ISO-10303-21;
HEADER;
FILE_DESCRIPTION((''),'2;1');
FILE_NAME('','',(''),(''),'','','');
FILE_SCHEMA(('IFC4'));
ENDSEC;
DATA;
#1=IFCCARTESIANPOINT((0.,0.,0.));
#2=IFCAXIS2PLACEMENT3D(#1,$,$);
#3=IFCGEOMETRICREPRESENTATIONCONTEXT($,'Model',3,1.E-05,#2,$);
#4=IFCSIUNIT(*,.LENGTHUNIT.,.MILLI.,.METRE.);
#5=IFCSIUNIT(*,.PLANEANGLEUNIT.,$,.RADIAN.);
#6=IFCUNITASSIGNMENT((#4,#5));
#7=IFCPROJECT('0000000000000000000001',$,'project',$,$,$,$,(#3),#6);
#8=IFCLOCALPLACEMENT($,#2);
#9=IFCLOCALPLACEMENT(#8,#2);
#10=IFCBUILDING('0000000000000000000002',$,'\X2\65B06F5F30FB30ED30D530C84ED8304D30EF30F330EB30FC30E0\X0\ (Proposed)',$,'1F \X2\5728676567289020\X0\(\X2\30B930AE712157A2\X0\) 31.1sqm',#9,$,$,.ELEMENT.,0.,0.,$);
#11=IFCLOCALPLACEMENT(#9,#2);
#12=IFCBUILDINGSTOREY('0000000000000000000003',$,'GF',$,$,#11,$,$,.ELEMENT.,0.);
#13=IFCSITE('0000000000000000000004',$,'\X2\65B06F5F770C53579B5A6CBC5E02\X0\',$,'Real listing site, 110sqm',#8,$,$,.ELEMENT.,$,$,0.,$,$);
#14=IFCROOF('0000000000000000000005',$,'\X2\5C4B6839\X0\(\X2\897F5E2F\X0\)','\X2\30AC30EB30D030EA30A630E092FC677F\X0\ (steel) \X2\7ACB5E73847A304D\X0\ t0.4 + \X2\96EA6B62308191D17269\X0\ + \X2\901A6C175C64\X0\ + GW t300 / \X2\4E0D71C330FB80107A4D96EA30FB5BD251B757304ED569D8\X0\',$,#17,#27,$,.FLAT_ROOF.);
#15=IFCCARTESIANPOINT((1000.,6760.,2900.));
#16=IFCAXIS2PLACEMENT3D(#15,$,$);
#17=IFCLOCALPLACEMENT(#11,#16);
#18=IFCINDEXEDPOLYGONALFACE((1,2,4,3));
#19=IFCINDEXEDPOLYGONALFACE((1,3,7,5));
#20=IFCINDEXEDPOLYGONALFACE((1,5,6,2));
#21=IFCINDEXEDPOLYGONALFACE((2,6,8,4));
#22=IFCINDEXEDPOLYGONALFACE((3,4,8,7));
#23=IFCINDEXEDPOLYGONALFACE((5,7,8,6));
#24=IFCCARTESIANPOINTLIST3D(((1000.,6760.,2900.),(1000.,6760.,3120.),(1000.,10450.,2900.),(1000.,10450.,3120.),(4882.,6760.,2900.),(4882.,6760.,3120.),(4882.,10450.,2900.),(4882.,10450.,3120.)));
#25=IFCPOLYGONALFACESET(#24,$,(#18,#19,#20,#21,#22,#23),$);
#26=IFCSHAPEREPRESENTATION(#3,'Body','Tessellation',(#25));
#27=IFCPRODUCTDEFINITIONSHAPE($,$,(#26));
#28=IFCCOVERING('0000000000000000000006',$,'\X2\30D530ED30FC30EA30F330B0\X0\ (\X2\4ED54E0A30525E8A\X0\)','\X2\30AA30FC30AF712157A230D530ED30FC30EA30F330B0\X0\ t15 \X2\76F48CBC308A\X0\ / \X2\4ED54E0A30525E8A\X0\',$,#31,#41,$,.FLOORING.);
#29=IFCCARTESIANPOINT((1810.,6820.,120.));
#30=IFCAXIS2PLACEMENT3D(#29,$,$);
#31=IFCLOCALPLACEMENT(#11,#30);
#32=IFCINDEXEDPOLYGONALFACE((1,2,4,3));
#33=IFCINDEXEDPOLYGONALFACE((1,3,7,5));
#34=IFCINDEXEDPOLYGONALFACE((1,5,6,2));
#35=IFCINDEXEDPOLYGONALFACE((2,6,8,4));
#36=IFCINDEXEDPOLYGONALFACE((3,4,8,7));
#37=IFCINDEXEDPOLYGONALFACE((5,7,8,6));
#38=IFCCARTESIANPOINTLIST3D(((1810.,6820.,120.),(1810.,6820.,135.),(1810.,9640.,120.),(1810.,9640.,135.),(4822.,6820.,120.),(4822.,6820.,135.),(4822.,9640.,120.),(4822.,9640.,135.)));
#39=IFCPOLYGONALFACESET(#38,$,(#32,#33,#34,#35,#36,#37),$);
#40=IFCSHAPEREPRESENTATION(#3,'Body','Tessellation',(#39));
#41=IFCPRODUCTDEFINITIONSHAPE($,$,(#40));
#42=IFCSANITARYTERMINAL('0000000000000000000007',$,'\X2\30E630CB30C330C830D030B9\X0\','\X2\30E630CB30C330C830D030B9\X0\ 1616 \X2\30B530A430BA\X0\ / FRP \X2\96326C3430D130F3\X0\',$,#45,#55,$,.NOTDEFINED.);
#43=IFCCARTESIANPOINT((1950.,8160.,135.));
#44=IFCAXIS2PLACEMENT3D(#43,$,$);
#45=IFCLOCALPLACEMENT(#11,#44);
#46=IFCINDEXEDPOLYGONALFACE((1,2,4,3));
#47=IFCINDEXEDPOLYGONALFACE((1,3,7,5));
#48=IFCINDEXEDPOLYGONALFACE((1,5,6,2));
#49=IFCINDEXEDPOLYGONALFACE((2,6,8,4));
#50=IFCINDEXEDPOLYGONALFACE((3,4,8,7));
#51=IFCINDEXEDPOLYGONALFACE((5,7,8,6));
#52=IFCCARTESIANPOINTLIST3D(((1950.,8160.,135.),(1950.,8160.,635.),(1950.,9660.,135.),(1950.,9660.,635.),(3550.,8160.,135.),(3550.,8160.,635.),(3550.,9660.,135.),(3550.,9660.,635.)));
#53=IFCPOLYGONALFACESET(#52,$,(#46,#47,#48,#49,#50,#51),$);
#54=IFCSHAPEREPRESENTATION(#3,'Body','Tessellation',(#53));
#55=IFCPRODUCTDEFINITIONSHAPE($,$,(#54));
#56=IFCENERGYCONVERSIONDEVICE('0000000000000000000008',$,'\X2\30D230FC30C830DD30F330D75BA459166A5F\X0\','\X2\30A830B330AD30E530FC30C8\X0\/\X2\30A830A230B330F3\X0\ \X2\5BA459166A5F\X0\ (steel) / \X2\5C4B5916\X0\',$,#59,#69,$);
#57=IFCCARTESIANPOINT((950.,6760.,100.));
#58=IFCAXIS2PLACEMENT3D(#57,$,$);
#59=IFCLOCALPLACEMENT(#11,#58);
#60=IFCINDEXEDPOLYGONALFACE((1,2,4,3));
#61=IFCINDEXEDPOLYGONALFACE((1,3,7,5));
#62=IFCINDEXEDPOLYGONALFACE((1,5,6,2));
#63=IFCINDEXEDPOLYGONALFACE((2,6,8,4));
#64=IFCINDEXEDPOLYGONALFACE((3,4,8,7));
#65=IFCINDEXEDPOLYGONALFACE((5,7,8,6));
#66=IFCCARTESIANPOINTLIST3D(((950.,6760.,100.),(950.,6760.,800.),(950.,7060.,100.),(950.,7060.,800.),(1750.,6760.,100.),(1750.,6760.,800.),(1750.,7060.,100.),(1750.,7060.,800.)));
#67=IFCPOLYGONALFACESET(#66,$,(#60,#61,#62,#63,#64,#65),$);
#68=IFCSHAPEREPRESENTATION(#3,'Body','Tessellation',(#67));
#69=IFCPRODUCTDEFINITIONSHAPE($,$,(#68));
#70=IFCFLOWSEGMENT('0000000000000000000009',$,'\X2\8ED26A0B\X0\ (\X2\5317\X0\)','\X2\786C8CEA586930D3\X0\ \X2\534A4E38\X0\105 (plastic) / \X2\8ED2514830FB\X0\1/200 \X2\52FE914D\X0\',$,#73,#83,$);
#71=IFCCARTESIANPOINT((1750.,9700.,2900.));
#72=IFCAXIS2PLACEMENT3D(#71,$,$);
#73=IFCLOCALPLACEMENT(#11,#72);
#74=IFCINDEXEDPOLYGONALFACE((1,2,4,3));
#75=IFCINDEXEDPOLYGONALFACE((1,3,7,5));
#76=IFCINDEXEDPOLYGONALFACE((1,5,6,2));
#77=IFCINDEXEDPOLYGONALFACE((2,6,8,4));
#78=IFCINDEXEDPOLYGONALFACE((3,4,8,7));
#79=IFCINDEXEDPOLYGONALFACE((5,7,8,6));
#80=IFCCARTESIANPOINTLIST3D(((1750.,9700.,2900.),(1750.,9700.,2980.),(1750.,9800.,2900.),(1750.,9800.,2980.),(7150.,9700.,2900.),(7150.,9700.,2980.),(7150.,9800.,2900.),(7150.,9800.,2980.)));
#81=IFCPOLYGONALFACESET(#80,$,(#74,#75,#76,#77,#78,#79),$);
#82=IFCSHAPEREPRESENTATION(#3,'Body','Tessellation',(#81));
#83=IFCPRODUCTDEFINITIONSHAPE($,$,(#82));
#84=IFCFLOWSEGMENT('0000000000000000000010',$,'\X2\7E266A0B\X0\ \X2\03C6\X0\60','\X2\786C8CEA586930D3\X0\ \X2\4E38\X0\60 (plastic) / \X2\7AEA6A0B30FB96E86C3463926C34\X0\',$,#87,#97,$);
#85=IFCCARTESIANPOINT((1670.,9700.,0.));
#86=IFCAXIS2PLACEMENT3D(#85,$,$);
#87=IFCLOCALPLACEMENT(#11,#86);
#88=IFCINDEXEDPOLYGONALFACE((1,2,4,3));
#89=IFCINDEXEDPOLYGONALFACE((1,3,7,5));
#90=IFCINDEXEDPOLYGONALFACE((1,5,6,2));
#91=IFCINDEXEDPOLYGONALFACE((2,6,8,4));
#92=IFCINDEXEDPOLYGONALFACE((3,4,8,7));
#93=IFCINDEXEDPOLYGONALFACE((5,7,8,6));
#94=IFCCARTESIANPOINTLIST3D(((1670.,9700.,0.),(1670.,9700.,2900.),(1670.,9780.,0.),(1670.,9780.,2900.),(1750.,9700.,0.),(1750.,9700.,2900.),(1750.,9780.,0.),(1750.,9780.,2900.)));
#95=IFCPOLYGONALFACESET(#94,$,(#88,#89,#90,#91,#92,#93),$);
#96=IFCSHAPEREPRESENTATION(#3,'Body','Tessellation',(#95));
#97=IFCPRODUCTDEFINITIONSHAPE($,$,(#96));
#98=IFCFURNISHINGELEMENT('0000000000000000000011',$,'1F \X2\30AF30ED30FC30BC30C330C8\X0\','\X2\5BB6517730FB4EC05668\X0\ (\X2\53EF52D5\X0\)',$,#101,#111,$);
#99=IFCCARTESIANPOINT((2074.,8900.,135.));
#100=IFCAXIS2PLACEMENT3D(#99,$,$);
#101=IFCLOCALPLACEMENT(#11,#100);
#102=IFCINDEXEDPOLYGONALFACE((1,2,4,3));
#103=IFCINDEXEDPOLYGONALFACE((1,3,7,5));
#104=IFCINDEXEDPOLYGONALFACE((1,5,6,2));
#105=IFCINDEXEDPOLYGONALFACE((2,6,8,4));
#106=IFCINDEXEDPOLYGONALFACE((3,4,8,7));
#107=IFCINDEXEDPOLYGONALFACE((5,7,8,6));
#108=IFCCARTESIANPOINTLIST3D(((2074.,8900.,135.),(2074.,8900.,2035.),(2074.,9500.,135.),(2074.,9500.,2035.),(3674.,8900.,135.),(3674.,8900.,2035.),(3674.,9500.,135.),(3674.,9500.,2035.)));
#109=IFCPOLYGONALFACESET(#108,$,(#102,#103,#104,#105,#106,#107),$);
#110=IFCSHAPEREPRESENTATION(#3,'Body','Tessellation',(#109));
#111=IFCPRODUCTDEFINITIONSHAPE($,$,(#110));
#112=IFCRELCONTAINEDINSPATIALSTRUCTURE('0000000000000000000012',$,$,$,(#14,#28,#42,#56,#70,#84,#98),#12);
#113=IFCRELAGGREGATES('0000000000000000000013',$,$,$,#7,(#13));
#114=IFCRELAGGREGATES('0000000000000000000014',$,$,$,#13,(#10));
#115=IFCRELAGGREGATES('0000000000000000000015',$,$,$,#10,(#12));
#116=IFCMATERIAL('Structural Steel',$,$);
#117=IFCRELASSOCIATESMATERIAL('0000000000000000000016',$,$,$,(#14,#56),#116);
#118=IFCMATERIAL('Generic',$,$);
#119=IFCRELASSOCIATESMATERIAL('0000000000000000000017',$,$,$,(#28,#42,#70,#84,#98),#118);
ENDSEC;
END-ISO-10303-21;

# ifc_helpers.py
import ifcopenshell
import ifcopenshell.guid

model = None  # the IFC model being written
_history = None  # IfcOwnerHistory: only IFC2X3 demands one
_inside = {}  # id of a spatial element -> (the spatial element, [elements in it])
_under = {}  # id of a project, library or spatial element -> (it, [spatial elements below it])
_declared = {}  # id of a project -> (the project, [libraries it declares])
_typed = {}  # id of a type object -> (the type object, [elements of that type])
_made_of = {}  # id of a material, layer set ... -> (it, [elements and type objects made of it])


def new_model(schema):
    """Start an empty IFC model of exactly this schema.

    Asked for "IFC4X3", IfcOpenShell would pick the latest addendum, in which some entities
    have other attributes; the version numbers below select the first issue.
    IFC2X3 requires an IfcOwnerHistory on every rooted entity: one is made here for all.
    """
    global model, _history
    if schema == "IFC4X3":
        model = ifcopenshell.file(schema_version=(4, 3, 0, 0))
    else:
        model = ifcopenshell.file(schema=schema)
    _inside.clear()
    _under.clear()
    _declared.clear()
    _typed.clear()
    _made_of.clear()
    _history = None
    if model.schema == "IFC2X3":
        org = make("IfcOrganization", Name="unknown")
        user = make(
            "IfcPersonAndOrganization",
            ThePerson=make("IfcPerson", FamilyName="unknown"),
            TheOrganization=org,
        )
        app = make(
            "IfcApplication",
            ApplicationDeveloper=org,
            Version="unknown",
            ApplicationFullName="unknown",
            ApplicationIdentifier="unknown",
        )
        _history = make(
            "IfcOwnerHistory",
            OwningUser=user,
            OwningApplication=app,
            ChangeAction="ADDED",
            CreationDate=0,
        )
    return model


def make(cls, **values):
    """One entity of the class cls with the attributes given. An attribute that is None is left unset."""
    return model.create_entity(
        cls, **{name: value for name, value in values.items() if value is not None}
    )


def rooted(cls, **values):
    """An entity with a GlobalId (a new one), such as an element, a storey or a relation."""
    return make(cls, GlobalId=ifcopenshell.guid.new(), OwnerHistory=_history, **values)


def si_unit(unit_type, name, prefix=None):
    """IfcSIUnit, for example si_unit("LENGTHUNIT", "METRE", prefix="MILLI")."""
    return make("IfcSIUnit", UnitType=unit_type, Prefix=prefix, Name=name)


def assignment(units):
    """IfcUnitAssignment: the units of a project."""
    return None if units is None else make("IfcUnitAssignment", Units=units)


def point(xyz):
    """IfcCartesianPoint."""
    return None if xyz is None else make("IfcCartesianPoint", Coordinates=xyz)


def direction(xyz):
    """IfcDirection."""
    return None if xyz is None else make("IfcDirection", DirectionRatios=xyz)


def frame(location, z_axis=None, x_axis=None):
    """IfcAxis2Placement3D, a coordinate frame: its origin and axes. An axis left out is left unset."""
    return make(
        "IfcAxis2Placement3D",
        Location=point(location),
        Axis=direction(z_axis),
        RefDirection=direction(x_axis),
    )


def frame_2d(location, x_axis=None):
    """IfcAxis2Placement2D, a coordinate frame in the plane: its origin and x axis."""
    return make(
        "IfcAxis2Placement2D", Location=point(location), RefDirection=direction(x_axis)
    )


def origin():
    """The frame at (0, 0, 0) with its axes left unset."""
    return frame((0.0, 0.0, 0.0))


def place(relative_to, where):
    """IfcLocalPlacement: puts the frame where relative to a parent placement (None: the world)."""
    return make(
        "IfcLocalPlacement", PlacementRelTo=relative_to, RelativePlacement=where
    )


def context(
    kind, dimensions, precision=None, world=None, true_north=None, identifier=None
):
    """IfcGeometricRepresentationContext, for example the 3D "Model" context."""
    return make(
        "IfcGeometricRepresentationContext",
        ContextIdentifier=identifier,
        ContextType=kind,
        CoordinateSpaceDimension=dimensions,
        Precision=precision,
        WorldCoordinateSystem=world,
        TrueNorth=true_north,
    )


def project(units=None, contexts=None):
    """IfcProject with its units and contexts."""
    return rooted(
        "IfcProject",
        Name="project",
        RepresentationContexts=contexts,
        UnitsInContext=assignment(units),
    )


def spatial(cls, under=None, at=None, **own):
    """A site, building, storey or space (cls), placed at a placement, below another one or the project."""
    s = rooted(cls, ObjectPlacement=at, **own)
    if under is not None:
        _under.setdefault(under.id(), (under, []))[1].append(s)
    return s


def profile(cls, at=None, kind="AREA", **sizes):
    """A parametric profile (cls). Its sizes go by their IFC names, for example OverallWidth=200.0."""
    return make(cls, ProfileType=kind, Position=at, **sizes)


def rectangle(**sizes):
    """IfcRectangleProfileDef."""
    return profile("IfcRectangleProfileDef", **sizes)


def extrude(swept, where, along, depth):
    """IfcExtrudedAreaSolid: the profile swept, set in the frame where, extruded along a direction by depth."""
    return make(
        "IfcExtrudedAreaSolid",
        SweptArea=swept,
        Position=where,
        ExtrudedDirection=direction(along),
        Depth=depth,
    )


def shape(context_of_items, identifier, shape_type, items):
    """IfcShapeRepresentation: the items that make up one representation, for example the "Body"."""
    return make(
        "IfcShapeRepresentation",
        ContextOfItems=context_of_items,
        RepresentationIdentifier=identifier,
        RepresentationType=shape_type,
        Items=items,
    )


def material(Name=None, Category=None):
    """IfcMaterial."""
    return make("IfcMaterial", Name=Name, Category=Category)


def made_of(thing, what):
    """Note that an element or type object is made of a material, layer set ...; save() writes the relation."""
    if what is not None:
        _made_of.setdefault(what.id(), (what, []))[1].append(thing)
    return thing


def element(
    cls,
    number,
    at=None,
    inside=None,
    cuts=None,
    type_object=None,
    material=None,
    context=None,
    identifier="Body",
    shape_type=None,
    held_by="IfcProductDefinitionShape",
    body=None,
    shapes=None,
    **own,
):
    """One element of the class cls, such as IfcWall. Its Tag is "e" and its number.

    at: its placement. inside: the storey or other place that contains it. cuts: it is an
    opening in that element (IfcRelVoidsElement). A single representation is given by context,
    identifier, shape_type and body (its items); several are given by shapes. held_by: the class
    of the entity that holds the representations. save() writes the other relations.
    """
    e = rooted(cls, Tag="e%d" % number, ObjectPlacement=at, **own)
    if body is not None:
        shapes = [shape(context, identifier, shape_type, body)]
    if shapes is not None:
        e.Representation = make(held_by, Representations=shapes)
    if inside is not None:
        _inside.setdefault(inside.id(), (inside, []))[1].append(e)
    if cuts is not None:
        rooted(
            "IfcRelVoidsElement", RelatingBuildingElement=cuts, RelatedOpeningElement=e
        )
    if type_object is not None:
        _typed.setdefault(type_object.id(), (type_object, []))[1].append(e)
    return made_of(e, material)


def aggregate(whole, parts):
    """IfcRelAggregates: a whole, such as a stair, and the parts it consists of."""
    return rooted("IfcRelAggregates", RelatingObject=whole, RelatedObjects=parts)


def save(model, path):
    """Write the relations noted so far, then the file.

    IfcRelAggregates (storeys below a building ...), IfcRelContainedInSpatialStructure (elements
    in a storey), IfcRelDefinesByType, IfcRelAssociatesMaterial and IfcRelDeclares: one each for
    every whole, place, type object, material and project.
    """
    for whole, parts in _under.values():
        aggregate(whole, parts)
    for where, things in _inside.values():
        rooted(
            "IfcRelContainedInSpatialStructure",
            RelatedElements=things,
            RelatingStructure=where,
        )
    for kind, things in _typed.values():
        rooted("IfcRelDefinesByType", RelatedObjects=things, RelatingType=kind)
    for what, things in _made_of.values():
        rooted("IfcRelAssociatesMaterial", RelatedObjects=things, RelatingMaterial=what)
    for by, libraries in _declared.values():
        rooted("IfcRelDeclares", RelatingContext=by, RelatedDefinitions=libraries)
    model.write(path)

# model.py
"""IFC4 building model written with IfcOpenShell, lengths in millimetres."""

from ifc_helpers import new_model, si_unit, frame, frame_2d, origin, place, context, project, spatial, rectangle, extrude, material, element, save


model = new_model("IFC4")

# Units and contexts
model_context = context("Model", 3, precision=1e-05, world=origin())
ifc_project = project(units=[si_unit("LENGTHUNIT", "METRE", prefix="MILLI"), si_unit("PLANEANGLEUNIT", "RADIAN")], contexts=[model_context])

# Site, building, storey
site_placement = place(None, origin())
site = spatial("IfcSite", under=ifc_project, at=site_placement, Name="新潟県南魚沼市", ObjectType="Real listing site, 110sqm", CompositionType="ELEMENT", RefElevation=0.0)
building_placement = place(site_placement, origin())
building = spatial("IfcBuilding", under=site, at=building_placement, Name="新潟・ロフト付きワンルーム (Proposed)", ObjectType="1F 在来木造(スギ無垢) 31.1sqm", CompositionType="ELEMENT", ElevationOfRefHeight=0.0, ElevationOfTerrain=0.0)
storey_placement = place(building_placement, origin())
storey = spatial("IfcBuildingStorey", under=building, at=storey_placement, Name="GF", CompositionType="ELEMENT", Elevation=0.0)

# Roof
ifc_material_1 = material(Name="Structural Steel")
roof_placement = place(storey_placement, frame((1000.0, 6760.0, 2900.0)))
element("IfcRoof", 1, at=roof_placement, inside=storey, material=ifc_material_1, Name="屋根(西帯)", Description="ガルバリウム鋼板 (steel) 立平葺き t0.4 + 雪止め金物 + 通気層 + GW t300 / 不燃・耐積雪・寒冷地仕様", PredefinedType="FLAT_ROOF", context=model_context, shape_type="SweptSolid", body=[
    extrude(rectangle(XDim=3882.0, YDim=3690.0, at=frame_2d((1941.0, 1845.0))), frame((1000.0, 6760.0, 2900.0)), (0.0, 0.0, 1.0), 220.0),
])

# Covering
ifc_material_2 = material(Name="Generic")
covering_placement = place(storey_placement, frame((1810.0, 6820.0, 120.0)))
element("IfcCovering", 2, at=covering_placement, inside=storey, material=ifc_material_2, Name="フローリング (仕上げ床)", Description="オーク無垢フローリング t15 直貼り / 仕上げ床", PredefinedType="FLOORING", context=model_context, shape_type="SweptSolid", body=[
    extrude(rectangle(XDim=3012.0, YDim=2820.0, at=frame_2d((1506.0, 1410.0))), frame((1810.0, 6820.0, 120.0)), (0.0, 0.0, 1.0), 15.0),
])

# Sanitary terminal
sanitary_terminal_placement = place(storey_placement, frame((1950.0, 8160.0, 135.0)))
element("IfcSanitaryTerminal", 3, at=sanitary_terminal_placement, inside=storey, material=ifc_material_2, Name="ユニットバス", Description="ユニットバス 1616 サイズ / FRP 防水パン", PredefinedType="NOTDEFINED", context=model_context, shape_type="SweptSolid", body=[
    extrude(rectangle(XDim=1600.0, YDim=1500.0, at=frame_2d((800.0, 750.0))), frame((1950.0, 8160.0, 135.0)), (0.0, 0.0, 1.0), 500.0),
])

# Energy conversion device
energy_conversion_device_placement = place(storey_placement, frame((950.0, 6760.0, 100.0)))
element("IfcEnergyConversionDevice", 4, at=energy_conversion_device_placement, inside=storey, material=ifc_material_1, Name="ヒートポンプ室外機", Description="エコキュート/エアコン 室外機 (steel) / 屋外", context=model_context, shape_type="SweptSolid", body=[
    extrude(rectangle(XDim=800.0, YDim=300.0, at=frame_2d((400.0, 150.0))), frame((950.0, 6760.0, 100.0)), (0.0, 0.0, 1.0), 700.0),
])

# Flow segments
flow_segment_1_placement = place(storey_placement, frame((1750.0, 9700.0, 2900.0)))
element("IfcFlowSegment", 5, at=flow_segment_1_placement, inside=storey, material=ifc_material_2, Name="軒樋 (北)", Description="硬質塩ビ 半丸105 (plastic) / 軒先・1/200 勾配", context=model_context, shape_type="SweptSolid", body=[
    extrude(rectangle(XDim=5400.0, YDim=100.0, at=frame_2d((2700.0, 50.0))), frame((1750.0, 9700.0, 2900.0)), (0.0, 0.0, 1.0), 80.0),
])
flow_segment_2_placement = place(storey_placement, frame((1670.0, 9700.0, 0.0)))
element("IfcFlowSegment", 6, at=flow_segment_2_placement, inside=storey, material=ifc_material_2, Name="縦樋 φ60", Description="硬質塩ビ 丸60 (plastic) / 竪樋・雨水排水", context=model_context, shape_type="SweptSolid", body=[
    extrude(rectangle(XDim=80.0, YDim=80.0, at=frame_2d((40.0, 40.0))), frame((1670.0, 9700.0, 0.0)), (0.0, 0.0, 1.0), 2900.0),
])

# Furnishing element
furnishing_placement = place(storey_placement, frame((2074.0, 8900.0, 135.0)))
element("IfcFurnishingElement", 7, at=furnishing_placement, inside=storey, material=ifc_material_2, Name="1F クローゼット", Description="家具・什器 (可動)", context=model_context, shape_type="SweptSolid", body=[
    extrude(rectangle(XDim=1600.0, YDim=600.0, at=frame_2d((800.0, 300.0))), frame((2074.0, 8900.0, 135.0)), (0.0, 0.0, 1.0), 1900.0),
])

save(model, "model.ifc")
